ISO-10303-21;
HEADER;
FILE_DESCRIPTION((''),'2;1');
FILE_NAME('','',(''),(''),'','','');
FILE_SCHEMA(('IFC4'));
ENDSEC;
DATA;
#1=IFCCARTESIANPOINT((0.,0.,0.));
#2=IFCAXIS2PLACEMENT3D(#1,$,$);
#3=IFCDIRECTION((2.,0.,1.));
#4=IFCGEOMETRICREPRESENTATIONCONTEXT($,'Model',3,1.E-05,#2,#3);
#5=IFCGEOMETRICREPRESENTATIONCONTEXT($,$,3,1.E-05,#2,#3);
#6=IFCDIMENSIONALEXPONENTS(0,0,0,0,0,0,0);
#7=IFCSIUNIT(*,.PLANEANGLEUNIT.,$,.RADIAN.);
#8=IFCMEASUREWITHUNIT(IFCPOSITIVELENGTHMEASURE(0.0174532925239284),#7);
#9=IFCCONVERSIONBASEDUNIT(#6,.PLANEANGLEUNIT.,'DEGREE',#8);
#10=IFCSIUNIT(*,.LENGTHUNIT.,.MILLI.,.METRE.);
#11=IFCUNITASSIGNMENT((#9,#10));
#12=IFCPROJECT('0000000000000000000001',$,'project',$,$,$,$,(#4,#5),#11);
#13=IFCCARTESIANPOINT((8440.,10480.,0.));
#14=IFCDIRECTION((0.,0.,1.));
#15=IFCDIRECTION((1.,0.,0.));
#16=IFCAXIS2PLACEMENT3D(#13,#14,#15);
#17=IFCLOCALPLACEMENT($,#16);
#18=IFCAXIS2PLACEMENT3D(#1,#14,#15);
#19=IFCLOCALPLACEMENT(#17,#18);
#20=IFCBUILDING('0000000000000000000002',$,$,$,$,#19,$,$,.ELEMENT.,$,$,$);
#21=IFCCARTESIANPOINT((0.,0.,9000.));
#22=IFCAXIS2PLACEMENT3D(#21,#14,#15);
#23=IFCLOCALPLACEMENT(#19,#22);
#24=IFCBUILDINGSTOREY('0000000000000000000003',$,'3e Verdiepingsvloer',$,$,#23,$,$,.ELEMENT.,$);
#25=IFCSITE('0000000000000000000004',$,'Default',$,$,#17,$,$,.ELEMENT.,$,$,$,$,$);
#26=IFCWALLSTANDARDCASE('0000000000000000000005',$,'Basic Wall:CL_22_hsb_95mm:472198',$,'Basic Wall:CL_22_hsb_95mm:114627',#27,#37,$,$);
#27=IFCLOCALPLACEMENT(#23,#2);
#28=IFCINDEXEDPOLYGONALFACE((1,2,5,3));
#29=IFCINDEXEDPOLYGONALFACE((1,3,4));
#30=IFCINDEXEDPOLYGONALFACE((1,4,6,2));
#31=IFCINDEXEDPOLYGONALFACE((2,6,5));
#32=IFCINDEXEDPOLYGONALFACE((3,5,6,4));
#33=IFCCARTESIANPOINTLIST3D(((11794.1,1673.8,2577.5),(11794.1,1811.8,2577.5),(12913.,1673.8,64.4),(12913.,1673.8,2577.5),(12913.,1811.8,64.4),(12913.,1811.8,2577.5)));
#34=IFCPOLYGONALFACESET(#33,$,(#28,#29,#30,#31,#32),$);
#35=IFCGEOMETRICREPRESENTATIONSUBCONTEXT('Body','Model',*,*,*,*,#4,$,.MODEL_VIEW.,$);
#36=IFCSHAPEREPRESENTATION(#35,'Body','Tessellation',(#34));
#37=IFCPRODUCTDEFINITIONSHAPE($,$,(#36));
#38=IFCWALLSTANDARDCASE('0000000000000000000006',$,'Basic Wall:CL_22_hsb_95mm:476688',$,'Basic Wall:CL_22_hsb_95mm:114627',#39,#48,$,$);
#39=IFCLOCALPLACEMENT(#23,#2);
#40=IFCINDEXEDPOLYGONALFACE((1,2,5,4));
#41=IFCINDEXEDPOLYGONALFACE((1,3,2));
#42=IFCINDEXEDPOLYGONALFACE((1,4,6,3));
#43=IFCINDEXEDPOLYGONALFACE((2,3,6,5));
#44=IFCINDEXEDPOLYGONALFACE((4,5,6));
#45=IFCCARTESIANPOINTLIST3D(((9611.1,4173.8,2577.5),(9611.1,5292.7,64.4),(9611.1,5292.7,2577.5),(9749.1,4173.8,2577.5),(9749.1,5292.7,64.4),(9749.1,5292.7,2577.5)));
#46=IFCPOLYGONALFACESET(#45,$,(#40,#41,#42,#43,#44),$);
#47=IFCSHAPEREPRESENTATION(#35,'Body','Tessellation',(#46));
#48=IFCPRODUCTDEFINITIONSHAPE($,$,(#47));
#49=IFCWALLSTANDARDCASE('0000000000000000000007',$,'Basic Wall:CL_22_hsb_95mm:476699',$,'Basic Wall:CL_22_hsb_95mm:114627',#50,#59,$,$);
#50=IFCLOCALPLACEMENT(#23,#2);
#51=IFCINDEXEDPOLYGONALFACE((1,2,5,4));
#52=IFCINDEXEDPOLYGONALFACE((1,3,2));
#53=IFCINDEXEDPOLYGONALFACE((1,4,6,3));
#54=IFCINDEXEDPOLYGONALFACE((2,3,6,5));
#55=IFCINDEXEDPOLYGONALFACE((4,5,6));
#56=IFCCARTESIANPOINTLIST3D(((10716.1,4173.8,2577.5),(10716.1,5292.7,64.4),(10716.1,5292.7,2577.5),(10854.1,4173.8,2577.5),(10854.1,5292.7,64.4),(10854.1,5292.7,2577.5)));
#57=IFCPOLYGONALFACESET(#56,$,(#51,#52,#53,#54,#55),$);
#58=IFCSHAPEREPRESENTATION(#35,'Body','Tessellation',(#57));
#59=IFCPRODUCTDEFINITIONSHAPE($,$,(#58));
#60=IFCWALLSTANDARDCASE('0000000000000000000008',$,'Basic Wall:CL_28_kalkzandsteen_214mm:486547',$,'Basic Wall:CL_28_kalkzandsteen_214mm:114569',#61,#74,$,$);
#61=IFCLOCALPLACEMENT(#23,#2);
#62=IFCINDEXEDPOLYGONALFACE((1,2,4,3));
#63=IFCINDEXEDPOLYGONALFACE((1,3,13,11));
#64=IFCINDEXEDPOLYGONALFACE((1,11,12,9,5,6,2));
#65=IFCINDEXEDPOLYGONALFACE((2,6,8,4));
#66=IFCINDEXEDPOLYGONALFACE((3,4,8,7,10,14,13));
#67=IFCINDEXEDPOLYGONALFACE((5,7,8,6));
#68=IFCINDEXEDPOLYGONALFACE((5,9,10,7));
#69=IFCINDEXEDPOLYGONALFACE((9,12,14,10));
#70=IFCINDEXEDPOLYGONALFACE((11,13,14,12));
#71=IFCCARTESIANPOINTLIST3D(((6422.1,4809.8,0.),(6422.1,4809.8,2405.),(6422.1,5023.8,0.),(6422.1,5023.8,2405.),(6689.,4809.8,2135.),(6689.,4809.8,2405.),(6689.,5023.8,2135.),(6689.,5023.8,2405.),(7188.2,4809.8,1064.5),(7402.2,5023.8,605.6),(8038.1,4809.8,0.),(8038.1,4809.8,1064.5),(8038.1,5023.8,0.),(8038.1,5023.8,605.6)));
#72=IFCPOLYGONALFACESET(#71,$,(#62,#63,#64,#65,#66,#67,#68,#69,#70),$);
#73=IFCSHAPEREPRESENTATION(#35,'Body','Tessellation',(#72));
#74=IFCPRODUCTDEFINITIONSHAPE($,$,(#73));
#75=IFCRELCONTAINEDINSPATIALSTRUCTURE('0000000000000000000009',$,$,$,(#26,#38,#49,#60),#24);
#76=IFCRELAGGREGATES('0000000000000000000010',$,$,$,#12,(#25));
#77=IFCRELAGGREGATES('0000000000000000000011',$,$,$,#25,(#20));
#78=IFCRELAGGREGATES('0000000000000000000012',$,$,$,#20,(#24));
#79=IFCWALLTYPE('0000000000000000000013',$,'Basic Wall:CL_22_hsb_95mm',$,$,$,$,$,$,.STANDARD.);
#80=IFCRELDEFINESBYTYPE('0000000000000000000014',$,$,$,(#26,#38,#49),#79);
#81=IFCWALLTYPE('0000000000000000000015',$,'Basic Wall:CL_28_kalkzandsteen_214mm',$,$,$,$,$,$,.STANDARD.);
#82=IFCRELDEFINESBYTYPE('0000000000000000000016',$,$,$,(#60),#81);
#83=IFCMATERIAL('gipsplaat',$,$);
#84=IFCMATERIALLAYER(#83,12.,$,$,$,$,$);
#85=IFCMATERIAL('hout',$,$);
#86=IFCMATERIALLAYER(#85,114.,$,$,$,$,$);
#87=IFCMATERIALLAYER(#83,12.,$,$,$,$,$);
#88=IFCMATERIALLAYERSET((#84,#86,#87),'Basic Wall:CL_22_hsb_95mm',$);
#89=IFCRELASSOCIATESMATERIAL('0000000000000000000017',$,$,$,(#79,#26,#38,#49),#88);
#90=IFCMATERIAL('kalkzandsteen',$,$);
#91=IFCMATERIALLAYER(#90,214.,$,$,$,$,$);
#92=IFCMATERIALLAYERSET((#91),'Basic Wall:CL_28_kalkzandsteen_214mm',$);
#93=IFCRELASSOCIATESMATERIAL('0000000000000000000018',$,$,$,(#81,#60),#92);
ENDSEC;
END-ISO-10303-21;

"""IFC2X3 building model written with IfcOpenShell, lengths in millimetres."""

from ifc_helpers import new_model, entity, si_unit, converted_unit, direction, frame, frame_2d, origin, origin_with_axes, place, context, subcontext, project, spatial, polyline, rectangle, extrude, clip, halfspace, bounded_halfspace, source, transform, mapped, material, layer, layer_set, layer_usage, type_object, element, save


model = new_model("IFC2X3")

# Units and contexts
model_context = context("Model", 3, precision=1e-05, world=origin(), true_north=direction((2.0, 0.0, 1.0)))
context_of_model = context(None, 3, precision=1e-05, world=origin(), true_north=direction((2.0, 0.0, 1.0)))
body_context = subcontext(model_context, "Body", "Model", "MODEL_VIEW")
ifc_project = project(units=[converted_unit("PLANEANGLEUNIT", "DEGREE", entity("IfcPositiveLengthMeasure", 0.0174532925239284), si_unit("PLANEANGLEUNIT", "RADIAN"), dimensions=[0, 0, 0, 0, 0, 0, 0]), si_unit("LENGTHUNIT", "METRE", prefix="MILLI")], contexts=[model_context, context_of_model])

# Site, building, storey
site_placement = place(None, frame((8440.0, 10480.0, 0.0), z_axis=(0.0, 0.0, 1.0), x_axis=(1.0, 0.0, 0.0)))
site = spatial("IfcSite", under=ifc_project, at=site_placement, Name="Default", CompositionType="ELEMENT")
building_placement = place(site_placement, origin_with_axes())
building = spatial("IfcBuilding", under=site, at=building_placement, CompositionType="ELEMENT")
storey_placement = place(building_placement, frame((0.0, 0.0, 9000.0), z_axis=(0.0, 0.0, 1.0), x_axis=(1.0, 0.0, 0.0)))
storey = spatial("IfcBuildingStorey", under=building, at=storey_placement, Name="3e Verdiepingsvloer", CompositionType="ELEMENT")

# Shared definitions
ifc_material_1 = material(Name="hout")

# Walls
ifc_material_2 = material(Name="gipsplaat")
ifc_layer_1 = layer(ifc_material_2, 12.0)
ifc_layer_2 = layer(ifc_material_1, 114.0)
ifc_layer_3 = layer(ifc_material_2, 12.0)
ifc_layer_set_1 = layer_set([ifc_layer_1, ifc_layer_2, ifc_layer_3], Name="Basic Wall:CL_22_hsb_95mm")
wall_type_1 = type_object("IfcWallType", Name="Basic Wall:CL_22_hsb_95mm", PredefinedType="STANDARD", material=ifc_layer_set_1)
shared_shape_1 = source(origin(), body_context, "Body", "Clipping", [
    clip(clip(extrude(rectangle(XDim=1118.9, YDim=138.0, at=frame_2d((559.5, 0.0), x_axis=(-1.0, 0.0))), origin(), (0.0, 0.0, 1.0), 2860.0), halfspace(frame((1118.9, -69.0, 64.4), z_axis=(-0.913545, 0.0, -0.406737), x_axis=(0.0, 1.0, 0.0)), False)), halfspace(frame((0.0, -69.0, 2577.5), z_axis=(0.0, 0.0, 1.0), x_axis=(0.0, 1.0, 0.0)), False)),
])
ifc_layer_usage_1 = layer_usage(ifc_layer_set_1, "AXIS2", "NEGATIVE", 69.0)
wall_1_placement = place(storey_placement, frame((11794.1, 1742.8, 0.0), z_axis=(0.0, 0.0, 1.0), x_axis=(1.0, 0.0, 0.0)))
element("IfcWallStandardCase", 1, at=wall_1_placement, inside=storey, type_object=wall_type_1, material=ifc_layer_usage_1, Name="Basic Wall:CL_22_hsb_95mm:472198", ObjectType="Basic Wall:CL_22_hsb_95mm:114627", context=body_context, shape_type="MappedRepresentation", body=[
    mapped(shared_shape_1, transform((0.0, 0.0, 0.0))),
])
ifc_layer_usage_2 = layer_usage(ifc_layer_set_1, "AXIS2", "NEGATIVE", 69.0)
wall_2_placement = place(storey_placement, frame((9680.1, 4173.8, 0.0), z_axis=(0.0, 0.0, 1.0), x_axis=(0.0, 1.0, 0.0)))
element("IfcWallStandardCase", 2, at=wall_2_placement, inside=storey, type_object=wall_type_1, material=ifc_layer_usage_2, Name="Basic Wall:CL_22_hsb_95mm:476688", ObjectType="Basic Wall:CL_22_hsb_95mm:114627", context=body_context, shape_type="MappedRepresentation", body=[
    mapped(shared_shape_1, transform((0.0, 0.0, 0.0))),
])
ifc_layer_usage_3 = layer_usage(ifc_layer_set_1, "AXIS2", "NEGATIVE", 69.0)
wall_3_placement = place(storey_placement, frame((10785.1, 4173.8, 0.0), z_axis=(0.0, 0.0, 1.0), x_axis=(0.0, 1.0, 0.0)))
element("IfcWallStandardCase", 3, at=wall_3_placement, inside=storey, type_object=wall_type_1, material=ifc_layer_usage_3, Name="Basic Wall:CL_22_hsb_95mm:476699", ObjectType="Basic Wall:CL_22_hsb_95mm:114627", context=body_context, shape_type="MappedRepresentation", body=[
    mapped(shared_shape_1, transform((0.0, 0.0, 0.0))),
])
ifc_material_3 = material(Name="kalkzandsteen")
ifc_layer_4 = layer(ifc_material_3, 214.0)
ifc_layer_set_2 = layer_set([ifc_layer_4], Name="Basic Wall:CL_28_kalkzandsteen_214mm")
ifc_layer_usage_4 = layer_usage(ifc_layer_set_2, "AXIS2", "NEGATIVE", 107.0)
wall_type_2 = type_object("IfcWallType", Name="Basic Wall:CL_28_kalkzandsteen_214mm", PredefinedType="STANDARD", material=ifc_layer_set_2)
wall_4_placement = place(storey_placement, frame((8038.1, 4916.8, 0.0), z_axis=(0.0, 0.0, 1.0), x_axis=(-1.0, 0.0, 0.0)))
element("IfcWallStandardCase", 4, at=wall_4_placement, inside=storey, type_object=wall_type_2, material=ifc_layer_usage_4, Name="Basic Wall:CL_28_kalkzandsteen_214mm:486547", ObjectType="Basic Wall:CL_28_kalkzandsteen_214mm:114569", context=body_context, shape_type="Clipping", body=[
    clip(clip(clip(extrude(rectangle(XDim=1616.0, YDim=214.0, at=frame_2d((808.0, 0.0), x_axis=(-1.0, 0.0))), origin(), (0.0, 0.0, 1.0), 2640.0), bounded_halfspace(frame((1349.1, -107.0, 2405.0), z_axis=(0.0, 0.0, 1.0), x_axis=(-1.0, 0.0, 0.0)), False, frame((1349.1, -107.0, 2405.0)), polyline([(0.0, 0.0), (266.9, 0.0), (266.9, 214.0), (0.0, 214.0), (0.0, 0.0)]))), bounded_halfspace(frame((0.0, -107.0, 605.6), z_axis=(0.0, -0.906308, 0.422618), x_axis=(1.0, 0.0, 0.0)), False, frame((0.0, -107.0, 605.6)), polyline([(0.0, 0.0), (635.9, 0.0), (849.9, 214.0), (0.0, 214.0), (0.0, 0.0)]))), bounded_halfspace(frame((635.9, -107.0, 605.6), z_axis=(-0.906308, 0.0, 0.422618), x_axis=(0.0, -1.0, 0.0)), False, frame((635.9, -107.0, 605.6)), polyline([(0.0, 0.0), (713.2, 0.0), (713.2, 214.0), (214.0, 214.0), (0.0, 0.0)]))),
])

save(model, "model.ifc")
